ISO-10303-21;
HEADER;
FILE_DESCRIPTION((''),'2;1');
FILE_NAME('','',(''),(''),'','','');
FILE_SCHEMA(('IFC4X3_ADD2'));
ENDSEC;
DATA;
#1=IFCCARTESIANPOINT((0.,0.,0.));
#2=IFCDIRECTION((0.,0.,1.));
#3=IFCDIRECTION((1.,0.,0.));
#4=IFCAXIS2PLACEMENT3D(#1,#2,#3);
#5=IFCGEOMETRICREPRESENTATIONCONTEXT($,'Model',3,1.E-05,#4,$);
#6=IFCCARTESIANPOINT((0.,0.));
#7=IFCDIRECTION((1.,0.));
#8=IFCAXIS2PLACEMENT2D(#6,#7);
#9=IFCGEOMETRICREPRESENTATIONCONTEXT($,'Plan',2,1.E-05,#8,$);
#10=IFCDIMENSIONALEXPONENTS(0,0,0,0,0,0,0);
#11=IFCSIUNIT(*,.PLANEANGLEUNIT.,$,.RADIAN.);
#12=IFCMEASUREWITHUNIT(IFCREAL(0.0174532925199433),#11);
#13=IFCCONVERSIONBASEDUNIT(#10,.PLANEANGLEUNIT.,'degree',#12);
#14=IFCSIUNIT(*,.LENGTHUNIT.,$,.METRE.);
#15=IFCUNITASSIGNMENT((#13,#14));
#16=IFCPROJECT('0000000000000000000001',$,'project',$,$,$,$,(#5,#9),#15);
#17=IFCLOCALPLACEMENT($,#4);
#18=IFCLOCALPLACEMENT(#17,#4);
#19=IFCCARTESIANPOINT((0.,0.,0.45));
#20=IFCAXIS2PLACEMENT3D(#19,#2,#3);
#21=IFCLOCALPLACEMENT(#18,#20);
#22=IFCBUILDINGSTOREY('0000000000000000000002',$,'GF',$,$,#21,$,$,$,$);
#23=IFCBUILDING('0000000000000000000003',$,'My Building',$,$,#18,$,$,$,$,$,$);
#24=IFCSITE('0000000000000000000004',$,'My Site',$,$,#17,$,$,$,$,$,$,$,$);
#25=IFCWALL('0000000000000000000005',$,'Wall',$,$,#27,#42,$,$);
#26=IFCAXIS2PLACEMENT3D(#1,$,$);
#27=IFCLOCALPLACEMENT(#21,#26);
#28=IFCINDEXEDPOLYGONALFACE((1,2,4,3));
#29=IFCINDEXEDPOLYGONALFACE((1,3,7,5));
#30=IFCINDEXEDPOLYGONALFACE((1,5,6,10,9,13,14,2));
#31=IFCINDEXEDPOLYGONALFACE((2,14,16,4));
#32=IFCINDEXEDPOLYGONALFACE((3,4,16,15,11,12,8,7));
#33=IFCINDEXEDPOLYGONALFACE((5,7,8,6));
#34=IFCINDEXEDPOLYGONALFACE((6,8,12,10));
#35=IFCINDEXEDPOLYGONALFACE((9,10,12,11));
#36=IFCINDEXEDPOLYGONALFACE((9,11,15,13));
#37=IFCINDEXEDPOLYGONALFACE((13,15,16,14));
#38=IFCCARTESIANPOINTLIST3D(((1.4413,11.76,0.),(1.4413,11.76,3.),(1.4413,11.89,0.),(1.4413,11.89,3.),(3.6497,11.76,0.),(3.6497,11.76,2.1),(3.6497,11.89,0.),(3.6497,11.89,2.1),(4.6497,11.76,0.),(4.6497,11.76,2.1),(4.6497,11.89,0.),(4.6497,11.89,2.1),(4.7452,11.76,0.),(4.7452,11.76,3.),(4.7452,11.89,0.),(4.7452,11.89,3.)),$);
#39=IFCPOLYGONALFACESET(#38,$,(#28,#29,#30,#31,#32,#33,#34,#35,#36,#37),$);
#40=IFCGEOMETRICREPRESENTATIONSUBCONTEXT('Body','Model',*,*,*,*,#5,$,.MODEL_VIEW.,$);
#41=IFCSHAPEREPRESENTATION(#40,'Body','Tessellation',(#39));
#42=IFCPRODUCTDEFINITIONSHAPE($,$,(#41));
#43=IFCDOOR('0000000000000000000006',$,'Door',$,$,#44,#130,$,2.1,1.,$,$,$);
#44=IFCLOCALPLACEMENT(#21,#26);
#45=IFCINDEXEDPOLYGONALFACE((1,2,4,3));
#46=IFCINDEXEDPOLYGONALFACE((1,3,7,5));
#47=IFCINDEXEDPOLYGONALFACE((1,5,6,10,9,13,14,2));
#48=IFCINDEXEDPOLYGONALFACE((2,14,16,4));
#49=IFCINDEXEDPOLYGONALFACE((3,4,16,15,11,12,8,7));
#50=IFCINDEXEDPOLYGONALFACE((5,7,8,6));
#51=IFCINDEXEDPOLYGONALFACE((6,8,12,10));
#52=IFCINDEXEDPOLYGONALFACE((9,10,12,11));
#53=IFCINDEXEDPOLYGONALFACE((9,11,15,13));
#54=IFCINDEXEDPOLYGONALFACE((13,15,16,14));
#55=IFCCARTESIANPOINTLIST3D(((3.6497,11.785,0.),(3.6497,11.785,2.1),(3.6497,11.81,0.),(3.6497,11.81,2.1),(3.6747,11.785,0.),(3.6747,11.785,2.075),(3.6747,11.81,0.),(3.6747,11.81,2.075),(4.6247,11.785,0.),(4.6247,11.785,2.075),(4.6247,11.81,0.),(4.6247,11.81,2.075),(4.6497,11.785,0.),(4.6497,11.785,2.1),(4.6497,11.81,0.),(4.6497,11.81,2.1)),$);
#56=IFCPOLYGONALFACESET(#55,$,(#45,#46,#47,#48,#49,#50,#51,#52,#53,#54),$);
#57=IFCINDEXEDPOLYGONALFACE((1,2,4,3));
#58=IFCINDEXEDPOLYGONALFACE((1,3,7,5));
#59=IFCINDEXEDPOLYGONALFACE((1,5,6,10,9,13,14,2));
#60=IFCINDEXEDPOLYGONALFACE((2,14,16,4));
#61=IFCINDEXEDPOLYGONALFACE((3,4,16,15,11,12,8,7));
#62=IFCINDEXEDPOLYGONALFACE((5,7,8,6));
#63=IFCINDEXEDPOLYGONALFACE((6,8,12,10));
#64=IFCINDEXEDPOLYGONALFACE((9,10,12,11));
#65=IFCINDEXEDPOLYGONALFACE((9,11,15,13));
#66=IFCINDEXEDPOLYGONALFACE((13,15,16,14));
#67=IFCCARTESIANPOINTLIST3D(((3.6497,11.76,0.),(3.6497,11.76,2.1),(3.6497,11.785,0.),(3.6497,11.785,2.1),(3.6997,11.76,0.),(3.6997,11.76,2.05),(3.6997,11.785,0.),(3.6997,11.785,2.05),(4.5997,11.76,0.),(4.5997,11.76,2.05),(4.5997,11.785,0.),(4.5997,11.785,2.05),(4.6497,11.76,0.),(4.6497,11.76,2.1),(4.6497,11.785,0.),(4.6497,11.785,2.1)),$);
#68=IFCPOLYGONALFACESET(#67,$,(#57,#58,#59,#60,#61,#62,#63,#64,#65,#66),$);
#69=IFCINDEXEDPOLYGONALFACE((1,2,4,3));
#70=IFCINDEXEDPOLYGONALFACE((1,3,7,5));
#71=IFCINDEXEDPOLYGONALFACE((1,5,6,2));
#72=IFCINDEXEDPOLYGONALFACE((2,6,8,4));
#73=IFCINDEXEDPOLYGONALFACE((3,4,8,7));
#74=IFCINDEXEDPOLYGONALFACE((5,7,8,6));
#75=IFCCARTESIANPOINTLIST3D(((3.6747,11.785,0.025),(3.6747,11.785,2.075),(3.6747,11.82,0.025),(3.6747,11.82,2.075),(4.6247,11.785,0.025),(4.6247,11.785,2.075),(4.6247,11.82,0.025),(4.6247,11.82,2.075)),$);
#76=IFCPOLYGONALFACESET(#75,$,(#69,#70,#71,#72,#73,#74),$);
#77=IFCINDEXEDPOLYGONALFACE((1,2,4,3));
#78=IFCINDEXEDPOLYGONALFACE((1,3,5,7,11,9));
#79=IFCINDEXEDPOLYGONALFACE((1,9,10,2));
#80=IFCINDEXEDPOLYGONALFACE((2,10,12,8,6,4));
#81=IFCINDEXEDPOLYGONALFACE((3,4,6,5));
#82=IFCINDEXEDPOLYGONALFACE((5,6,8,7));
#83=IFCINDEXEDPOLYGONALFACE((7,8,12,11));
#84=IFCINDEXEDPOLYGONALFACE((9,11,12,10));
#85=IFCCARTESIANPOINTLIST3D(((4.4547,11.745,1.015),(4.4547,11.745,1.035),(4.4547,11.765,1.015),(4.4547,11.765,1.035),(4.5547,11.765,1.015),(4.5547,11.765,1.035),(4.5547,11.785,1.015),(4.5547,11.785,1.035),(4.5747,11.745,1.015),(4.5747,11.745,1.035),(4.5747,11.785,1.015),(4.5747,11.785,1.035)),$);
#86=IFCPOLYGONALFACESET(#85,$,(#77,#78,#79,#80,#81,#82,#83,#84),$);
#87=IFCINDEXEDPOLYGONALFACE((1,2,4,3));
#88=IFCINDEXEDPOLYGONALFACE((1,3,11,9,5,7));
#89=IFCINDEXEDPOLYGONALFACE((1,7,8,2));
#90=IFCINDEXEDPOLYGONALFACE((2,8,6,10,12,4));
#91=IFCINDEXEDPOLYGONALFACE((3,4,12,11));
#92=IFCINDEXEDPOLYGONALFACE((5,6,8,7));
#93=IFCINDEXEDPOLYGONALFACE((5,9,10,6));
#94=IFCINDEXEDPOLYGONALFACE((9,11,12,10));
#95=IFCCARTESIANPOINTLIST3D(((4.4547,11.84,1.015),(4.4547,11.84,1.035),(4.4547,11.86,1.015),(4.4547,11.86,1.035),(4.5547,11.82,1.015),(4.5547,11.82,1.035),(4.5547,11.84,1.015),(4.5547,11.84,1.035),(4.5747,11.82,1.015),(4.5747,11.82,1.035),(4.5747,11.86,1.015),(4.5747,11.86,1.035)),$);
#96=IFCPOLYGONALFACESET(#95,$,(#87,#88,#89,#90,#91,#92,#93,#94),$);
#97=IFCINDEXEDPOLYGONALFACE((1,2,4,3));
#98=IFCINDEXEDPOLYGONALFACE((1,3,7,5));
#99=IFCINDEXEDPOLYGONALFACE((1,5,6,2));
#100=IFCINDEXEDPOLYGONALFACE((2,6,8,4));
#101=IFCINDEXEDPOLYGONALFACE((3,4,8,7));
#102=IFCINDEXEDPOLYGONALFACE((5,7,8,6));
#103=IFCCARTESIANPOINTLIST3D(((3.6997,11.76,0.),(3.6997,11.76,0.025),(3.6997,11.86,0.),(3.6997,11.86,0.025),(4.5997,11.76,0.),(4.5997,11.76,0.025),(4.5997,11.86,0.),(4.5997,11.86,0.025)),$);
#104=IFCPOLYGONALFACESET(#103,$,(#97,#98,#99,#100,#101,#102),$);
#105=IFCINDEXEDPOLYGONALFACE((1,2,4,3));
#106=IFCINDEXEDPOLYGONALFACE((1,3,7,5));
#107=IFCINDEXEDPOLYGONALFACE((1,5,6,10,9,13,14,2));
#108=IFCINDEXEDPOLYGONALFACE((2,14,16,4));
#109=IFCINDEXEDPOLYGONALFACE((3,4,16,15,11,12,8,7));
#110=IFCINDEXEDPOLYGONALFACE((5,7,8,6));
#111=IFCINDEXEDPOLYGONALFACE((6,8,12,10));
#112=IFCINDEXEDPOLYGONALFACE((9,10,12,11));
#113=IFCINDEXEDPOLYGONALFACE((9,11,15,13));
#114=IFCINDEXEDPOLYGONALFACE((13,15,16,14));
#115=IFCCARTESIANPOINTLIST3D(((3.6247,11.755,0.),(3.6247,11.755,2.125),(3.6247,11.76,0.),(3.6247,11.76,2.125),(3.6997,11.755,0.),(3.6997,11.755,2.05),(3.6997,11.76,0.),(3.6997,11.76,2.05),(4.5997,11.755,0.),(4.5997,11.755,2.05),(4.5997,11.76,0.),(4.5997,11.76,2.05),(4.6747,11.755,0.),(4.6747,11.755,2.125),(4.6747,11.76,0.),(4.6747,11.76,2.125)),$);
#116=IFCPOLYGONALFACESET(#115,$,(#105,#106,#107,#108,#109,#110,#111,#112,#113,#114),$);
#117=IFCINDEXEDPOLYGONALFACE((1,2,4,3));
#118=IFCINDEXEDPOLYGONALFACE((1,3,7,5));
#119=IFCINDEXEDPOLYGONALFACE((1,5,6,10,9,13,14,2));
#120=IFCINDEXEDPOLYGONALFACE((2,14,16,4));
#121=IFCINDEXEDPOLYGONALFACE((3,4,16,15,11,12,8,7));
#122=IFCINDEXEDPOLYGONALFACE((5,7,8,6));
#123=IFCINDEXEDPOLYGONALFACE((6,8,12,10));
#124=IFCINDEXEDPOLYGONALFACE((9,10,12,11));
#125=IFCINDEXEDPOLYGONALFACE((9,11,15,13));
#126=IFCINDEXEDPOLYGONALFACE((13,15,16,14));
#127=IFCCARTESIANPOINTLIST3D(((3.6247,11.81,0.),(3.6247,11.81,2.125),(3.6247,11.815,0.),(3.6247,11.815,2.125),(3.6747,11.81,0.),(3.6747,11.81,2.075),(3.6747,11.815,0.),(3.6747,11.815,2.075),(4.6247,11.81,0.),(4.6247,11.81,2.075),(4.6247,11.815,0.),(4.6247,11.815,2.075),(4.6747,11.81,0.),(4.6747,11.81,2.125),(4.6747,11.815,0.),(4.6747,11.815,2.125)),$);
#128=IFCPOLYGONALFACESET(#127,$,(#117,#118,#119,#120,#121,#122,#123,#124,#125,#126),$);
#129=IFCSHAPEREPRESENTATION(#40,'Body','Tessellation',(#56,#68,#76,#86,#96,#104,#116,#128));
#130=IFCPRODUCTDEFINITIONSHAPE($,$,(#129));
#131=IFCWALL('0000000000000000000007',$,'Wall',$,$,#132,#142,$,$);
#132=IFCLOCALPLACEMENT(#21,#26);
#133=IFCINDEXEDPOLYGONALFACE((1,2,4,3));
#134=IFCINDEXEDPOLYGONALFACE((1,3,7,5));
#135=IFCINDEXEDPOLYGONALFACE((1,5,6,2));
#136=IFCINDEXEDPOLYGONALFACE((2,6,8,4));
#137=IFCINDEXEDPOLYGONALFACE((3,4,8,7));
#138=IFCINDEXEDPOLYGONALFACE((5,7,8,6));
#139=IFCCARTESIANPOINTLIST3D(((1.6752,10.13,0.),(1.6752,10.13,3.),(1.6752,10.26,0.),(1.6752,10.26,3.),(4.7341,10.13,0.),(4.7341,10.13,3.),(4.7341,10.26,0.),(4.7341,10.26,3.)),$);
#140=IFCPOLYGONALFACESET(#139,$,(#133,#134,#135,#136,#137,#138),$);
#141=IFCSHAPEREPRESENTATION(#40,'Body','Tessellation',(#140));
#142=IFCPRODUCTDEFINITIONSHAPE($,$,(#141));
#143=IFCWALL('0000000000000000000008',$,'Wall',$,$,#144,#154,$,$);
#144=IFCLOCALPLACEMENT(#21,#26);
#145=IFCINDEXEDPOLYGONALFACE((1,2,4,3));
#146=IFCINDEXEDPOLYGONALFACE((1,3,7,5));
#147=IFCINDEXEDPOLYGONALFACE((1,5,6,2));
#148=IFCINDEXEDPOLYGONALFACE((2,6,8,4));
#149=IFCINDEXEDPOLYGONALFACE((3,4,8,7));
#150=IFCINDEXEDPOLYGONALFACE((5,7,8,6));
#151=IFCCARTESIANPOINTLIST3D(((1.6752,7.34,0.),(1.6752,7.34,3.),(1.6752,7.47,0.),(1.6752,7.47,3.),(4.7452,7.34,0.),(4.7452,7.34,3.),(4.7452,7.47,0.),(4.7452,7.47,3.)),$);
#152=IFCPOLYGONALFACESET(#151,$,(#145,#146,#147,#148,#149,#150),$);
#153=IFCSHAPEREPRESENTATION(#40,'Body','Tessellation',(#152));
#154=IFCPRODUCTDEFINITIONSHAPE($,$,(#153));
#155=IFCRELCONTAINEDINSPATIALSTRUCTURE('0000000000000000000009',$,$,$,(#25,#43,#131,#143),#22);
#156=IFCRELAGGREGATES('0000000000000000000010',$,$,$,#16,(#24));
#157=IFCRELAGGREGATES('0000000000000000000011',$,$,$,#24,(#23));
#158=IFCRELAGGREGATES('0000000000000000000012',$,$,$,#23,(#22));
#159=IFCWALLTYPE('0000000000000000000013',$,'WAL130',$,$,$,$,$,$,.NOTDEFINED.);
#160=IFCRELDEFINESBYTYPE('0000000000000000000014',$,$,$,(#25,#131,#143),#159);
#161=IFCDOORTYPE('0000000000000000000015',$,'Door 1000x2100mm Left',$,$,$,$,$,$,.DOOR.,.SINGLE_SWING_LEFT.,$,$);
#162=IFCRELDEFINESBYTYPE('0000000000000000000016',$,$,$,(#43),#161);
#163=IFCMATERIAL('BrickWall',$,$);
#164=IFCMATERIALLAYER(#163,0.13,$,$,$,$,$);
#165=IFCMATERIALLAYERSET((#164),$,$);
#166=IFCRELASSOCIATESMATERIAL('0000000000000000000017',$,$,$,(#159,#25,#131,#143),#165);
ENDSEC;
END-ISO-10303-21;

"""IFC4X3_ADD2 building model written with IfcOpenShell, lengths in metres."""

from ifc_helpers import new_model, entity, si_unit, converted_unit, frame, origin_with_axes, origin_2d_with_axis, place, context, subcontext, project, spatial, line, indexed_curve, outline, extrude, shape, source, transform, mapped, material, layer, layer_set, layer_usage, type_object, type_shapes, element, fill, save


model = new_model("IFC4X3_ADD2")

# Units and contexts
model_context = context("Model", 3, precision=1e-05, world=origin_with_axes())
plan_context = context("Plan", 2, precision=1e-05, world=origin_2d_with_axis())
body_context_1 = subcontext(model_context, "Body", "Model", "MODEL_VIEW")
body_context_2 = subcontext(plan_context, "Body", "Plan", "PLAN_VIEW")
ifc_project = project(units=[converted_unit("PLANEANGLEUNIT", "degree", entity("IfcReal", 0.0174532925199433), si_unit("PLANEANGLEUNIT", "RADIAN"), dimensions=[0, 0, 0, 0, 0, 0, 0]), si_unit("LENGTHUNIT", "METRE")], contexts=[model_context, plan_context])

# Site, building, storey
site_placement = place(None, origin_with_axes())
site = spatial("IfcSite", under=ifc_project, at=site_placement, Name="My Site")
building_placement = place(site_placement, origin_with_axes())
building = spatial("IfcBuilding", under=site, at=building_placement, Name="My Building")
storey_placement = place(building_placement, frame((0.0, 0.0, 0.45), z_axis=(0.0, 0.0, 1.0), x_axis=(1.0, 0.0, 0.0)))
storey = spatial("IfcBuildingStorey", under=building, at=storey_placement, Name="GF")

# Shared definitions
ifc_material_1 = material(Name="BrickWall")

# Wall, opening, door
ifc_layer_1 = layer(ifc_material_1, 0.13)
ifc_layer_set_1 = layer_set([ifc_layer_1])
ifc_layer_usage_1 = layer_usage(ifc_layer_set_1, "AXIS2", "POSITIVE", 0.0)
wall_type_1 = type_object("IfcWallType", Name="WAL130", PredefinedType="NOTDEFINED", material=ifc_layer_set_1)
wall_1_placement = place(storey_placement, frame((1.4413, 11.76, 0.0), z_axis=(0.0, 0.0, 1.0), x_axis=(1.0, 0.0, 0.0)))
wall_1 = element("IfcWall", 1, at=wall_1_placement, inside=storey, type_object=wall_type_1, material=ifc_layer_usage_1, Name="Wall", context=body_context_1, shape_type="SweptSolid", body=[
    extrude(outline(indexed_curve([(0.0, 0.0), (0.0, 0.13), (3.3038, 0.13), (3.3038, 0.0), (0.0, 0.0)], self_intersect=False)), origin_with_axes(), (0.0, 0.0, 1.0), 3.0),
])
shared_shape_1 = source(origin_with_axes(), body_context_1, "Body", "SweptSolid", [
    extrude(outline(indexed_curve([(0.0, 0.0), (1.0, 0.0), (1.0, 2.1), (0.0, 2.1)], segments=[line(1, 2, 3, 4, 1)])), frame((0.0, -0.6, 0.0), z_axis=(0.0, -1.0, 0.0), x_axis=(1.0, 0.0, 0.0)), (0.0, 0.0, -1.0), 1.2),
])
opening_1_placement = place(wall_1_placement, frame((2.2083, 0.0, 0.0), z_axis=(0.0, 0.0, 1.0), x_axis=(1.0, 0.0, 0.0)))
opening_1 = element("IfcOpeningElement", 2, at=opening_1_placement, cuts=wall_1, PredefinedType="OPENING", context=body_context_1, shape_type="MappedRepresentation", body=[
    mapped(shared_shape_1, transform((0.0, 0.0, 0.0), x_axis=(1.0, 0.0, 0.0), y_axis=(0.0, 1.0, 0.0), z_axis=(0.0, 0.0, 1.0), scale=1.0)),
])
door_type_1 = type_object("IfcDoorType", Name="Door 1000x2100mm Left", OperationType="SINGLE_SWING_LEFT", PredefinedType="DOOR")
shared_shape_2 = source(origin_with_axes(), body_context_1, "Body", "SweptSolid", [
    extrude(outline(indexed_curve([(0.0, 0.0), (0.0, 2.1), (1.0, 2.1), (1.0, 0.0), (0.975, 0.0), (0.975, 2.075), (0.025, 2.075), (0.025, 0.0)], segments=[line(1, 2, 3, 4, 5, 6, 7, 8, 1)])), frame((0.0, 0.025, 0.0), z_axis=(0.0, -1.0, 0.0), x_axis=(1.0, 0.0, 0.0)), (0.0, 0.0, -1.0), 0.025),
    extrude(outline(indexed_curve([(0.0, 0.0), (0.0, 2.1), (1.0, 2.1), (1.0, 0.0), (0.95, 0.0), (0.95, 2.05), (0.05, 2.05), (0.05, 0.0)], segments=[line(1, 2, 3, 4, 5, 6, 7, 8, 1)])), frame((0.0, 0.0, 0.0), z_axis=(0.0, -1.0, 0.0), x_axis=(1.0, 0.0, 0.0)), (0.0, 0.0, -1.0), 0.025),
    extrude(outline(indexed_curve([(0.0, 0.0), (0.95, 0.0), (0.95, 0.035), (0.0, 0.035)], segments=[line(1, 2, 3, 4, 1)])), frame((0.025, 0.025, 0.025), z_axis=(0.0, 0.0, 1.0), x_axis=(1.0, 0.0, 0.0)), (0.0, 0.0, 1.0), 2.05),
    extrude(outline(indexed_curve([(0.0, 0.0), (0.0, -0.04), (-0.12, -0.04), (-0.12, -0.02), (-0.02, -0.02), (-0.02, 0.0)], segments=[line(1, 2, 3, 4, 5, 6, 1)])), frame((0.925, 0.025, 1.015), z_axis=(0.0, 0.0, 1.0), x_axis=(1.0, 0.0, 0.0)), (0.0, 0.0, 1.0), 0.02),
    extrude(outline(indexed_curve([(0.0, 0.0), (0.0, 0.04), (-0.12, 0.04), (-0.12, 0.02), (-0.02, 0.02), (-0.02, 0.0)], segments=[line(1, 2, 3, 4, 5, 6, 1)])), frame((0.925, 0.06, 1.015), z_axis=(0.0, 0.0, 1.0), x_axis=(1.0, 0.0, 0.0)), (0.0, 0.0, 1.0), 0.02),
    extrude(outline(indexed_curve([(0.0, 0.0), (0.9, 0.0), (0.9, 0.1), (0.0, 0.1)], segments=[line(1, 2, 3, 4, 1)])), frame((0.05, 0.0, 0.0), z_axis=(0.0, 0.0, 1.0), x_axis=(1.0, 0.0, 0.0)), (0.0, 0.0, 1.0), 0.025),
    extrude(outline(indexed_curve([(0.0, 0.0), (0.0, 2.125), (1.05, 2.125), (1.05, 0.0), (0.975, 0.0), (0.975, 2.05), (0.075, 2.05), (0.075, 0.0)], segments=[line(1, 2, 3, 4, 5, 6, 7, 8, 1)])), frame((-0.025, -0.005, 0.0), z_axis=(0.0, -1.0, 0.0), x_axis=(1.0, 0.0, 0.0)), (0.0, 0.0, -1.0), 0.005),
    extrude(outline(indexed_curve([(0.0, 0.0), (0.0, 2.125), (1.05, 2.125), (1.05, 0.0), (1.0, 0.0), (1.0, 2.075), (0.05, 2.075), (0.05, 0.0)], segments=[line(1, 2, 3, 4, 5, 6, 7, 8, 1)])), frame((-0.025, 0.05, 0.0), z_axis=(0.0, -1.0, 0.0), x_axis=(1.0, 0.0, 0.0)), (0.0, 0.0, -1.0), 0.005),
])
shared_shape_3 = source(origin_with_axes(), body_context_2, "Body", "Curve2D", [
    entity("IfcIndexedPolyCurve", entity("IfcCartesianPointList2D", [[0.0, 0.0], [0.0, 0.05], [0.025, 0.05], [0.025, 0.025], [0.05, 0.025], [0.05, 0.0]]), [entity("IfcLineIndex", [1, 2, 3, 4, 5, 6, 1])]),
    entity("IfcIndexedPolyCurve", entity("IfcCartesianPointList2D", [[1.0, 0.0], [1.0, 0.05], [0.975, 0.05], [0.975, 0.025], [0.95, 0.025], [0.95, 0.0]]), [entity("IfcLineIndex", [1, 2, 3, 4, 5, 6, 1])]),
    entity("IfcTrimmedCurve", entity("IfcEllipse", entity("IfcAxis2Placement2D", entity("IfcCartesianPoint", [0.06, 0.05]), entity("IfcDirection", [1.0, 0.0])), 0.915, 0.95), [entity("IfcCartesianPoint", [0.975, 0.05])], [entity("IfcCartesianPoint", [0.06, 1.0])], True, "CARTESIAN"),
    entity("IfcIndexedPolyCurve", entity("IfcCartesianPointList2D", [[0.025, 0.05], [0.06, 0.05], [0.06, 1.0], [0.025, 1.0]]), [entity("IfcLineIndex", [1, 2, 3, 4, 1])]),
])
type_shapes(door_type_1, [shared_shape_2, shared_shape_3])
door_1_placement = place(opening_1_placement, origin_with_axes())
door_1 = element("IfcDoor", 3, at=door_1_placement, inside=storey, type_object=door_type_1, Name="Door", OverallHeight=2.1, OverallWidth=1.0, shapes=[
    shape(body_context_1, "Body", "MappedRepresentation", [mapped(shared_shape_2, transform((0.0, 0.0, 0.0), x_axis=(1.0, 0.0, 0.0), y_axis=(0.0, 1.0, 0.0), z_axis=(0.0, 0.0, 1.0), scale=1.0))]),
    shape(body_context_2, "Body", "MappedRepresentation", [mapped(shared_shape_3, transform((0.0, 0.0, 0.0), x_axis=(1.0, 0.0, 0.0), y_axis=(0.0, 1.0, 0.0), z_axis=(0.0, 0.0, 1.0), scale=1.0))]),
])
fill(opening_1, door_1)

# Walls
ifc_layer_usage_2 = layer_usage(ifc_layer_set_1, "AXIS2", "POSITIVE", 0.0)
wall_2_placement = place(storey_placement, frame((1.6752, 10.13, 0.0), z_axis=(0.0, 0.0, 1.0), x_axis=(1.0, 0.0, 0.0)))
element("IfcWall", 4, at=wall_2_placement, inside=storey, type_object=wall_type_1, material=ifc_layer_usage_2, Name="Wall", context=body_context_1, shape_type="SweptSolid", body=[
    extrude(outline(indexed_curve([(0.0, 0.0), (0.0, 0.13), (3.0588, 0.13), (3.0588, 0.0), (0.0, 0.0)], self_intersect=False)), origin_with_axes(), (0.0, 0.0, 1.0), 3.0),
])
ifc_layer_usage_3 = layer_usage(ifc_layer_set_1, "AXIS2", "POSITIVE", 0.0)
wall_3_placement = place(storey_placement, frame((1.6752, 7.34, 0.0), z_axis=(0.0, 0.0, 1.0), x_axis=(1.0, 0.0, 0.0)))
element("IfcWall", 5, at=wall_3_placement, inside=storey, type_object=wall_type_1, material=ifc_layer_usage_3, Name="Wall", context=body_context_1, shape_type="SweptSolid", body=[
    extrude(outline(indexed_curve([(0.0, 0.0), (0.0, 0.13), (3.0699, 0.13), (3.0699, 0.0), (0.0, 0.0)], self_intersect=False)), origin_with_axes(), (0.0, 0.0, 1.0), 3.0),
])

save(model, "model.ifc")
